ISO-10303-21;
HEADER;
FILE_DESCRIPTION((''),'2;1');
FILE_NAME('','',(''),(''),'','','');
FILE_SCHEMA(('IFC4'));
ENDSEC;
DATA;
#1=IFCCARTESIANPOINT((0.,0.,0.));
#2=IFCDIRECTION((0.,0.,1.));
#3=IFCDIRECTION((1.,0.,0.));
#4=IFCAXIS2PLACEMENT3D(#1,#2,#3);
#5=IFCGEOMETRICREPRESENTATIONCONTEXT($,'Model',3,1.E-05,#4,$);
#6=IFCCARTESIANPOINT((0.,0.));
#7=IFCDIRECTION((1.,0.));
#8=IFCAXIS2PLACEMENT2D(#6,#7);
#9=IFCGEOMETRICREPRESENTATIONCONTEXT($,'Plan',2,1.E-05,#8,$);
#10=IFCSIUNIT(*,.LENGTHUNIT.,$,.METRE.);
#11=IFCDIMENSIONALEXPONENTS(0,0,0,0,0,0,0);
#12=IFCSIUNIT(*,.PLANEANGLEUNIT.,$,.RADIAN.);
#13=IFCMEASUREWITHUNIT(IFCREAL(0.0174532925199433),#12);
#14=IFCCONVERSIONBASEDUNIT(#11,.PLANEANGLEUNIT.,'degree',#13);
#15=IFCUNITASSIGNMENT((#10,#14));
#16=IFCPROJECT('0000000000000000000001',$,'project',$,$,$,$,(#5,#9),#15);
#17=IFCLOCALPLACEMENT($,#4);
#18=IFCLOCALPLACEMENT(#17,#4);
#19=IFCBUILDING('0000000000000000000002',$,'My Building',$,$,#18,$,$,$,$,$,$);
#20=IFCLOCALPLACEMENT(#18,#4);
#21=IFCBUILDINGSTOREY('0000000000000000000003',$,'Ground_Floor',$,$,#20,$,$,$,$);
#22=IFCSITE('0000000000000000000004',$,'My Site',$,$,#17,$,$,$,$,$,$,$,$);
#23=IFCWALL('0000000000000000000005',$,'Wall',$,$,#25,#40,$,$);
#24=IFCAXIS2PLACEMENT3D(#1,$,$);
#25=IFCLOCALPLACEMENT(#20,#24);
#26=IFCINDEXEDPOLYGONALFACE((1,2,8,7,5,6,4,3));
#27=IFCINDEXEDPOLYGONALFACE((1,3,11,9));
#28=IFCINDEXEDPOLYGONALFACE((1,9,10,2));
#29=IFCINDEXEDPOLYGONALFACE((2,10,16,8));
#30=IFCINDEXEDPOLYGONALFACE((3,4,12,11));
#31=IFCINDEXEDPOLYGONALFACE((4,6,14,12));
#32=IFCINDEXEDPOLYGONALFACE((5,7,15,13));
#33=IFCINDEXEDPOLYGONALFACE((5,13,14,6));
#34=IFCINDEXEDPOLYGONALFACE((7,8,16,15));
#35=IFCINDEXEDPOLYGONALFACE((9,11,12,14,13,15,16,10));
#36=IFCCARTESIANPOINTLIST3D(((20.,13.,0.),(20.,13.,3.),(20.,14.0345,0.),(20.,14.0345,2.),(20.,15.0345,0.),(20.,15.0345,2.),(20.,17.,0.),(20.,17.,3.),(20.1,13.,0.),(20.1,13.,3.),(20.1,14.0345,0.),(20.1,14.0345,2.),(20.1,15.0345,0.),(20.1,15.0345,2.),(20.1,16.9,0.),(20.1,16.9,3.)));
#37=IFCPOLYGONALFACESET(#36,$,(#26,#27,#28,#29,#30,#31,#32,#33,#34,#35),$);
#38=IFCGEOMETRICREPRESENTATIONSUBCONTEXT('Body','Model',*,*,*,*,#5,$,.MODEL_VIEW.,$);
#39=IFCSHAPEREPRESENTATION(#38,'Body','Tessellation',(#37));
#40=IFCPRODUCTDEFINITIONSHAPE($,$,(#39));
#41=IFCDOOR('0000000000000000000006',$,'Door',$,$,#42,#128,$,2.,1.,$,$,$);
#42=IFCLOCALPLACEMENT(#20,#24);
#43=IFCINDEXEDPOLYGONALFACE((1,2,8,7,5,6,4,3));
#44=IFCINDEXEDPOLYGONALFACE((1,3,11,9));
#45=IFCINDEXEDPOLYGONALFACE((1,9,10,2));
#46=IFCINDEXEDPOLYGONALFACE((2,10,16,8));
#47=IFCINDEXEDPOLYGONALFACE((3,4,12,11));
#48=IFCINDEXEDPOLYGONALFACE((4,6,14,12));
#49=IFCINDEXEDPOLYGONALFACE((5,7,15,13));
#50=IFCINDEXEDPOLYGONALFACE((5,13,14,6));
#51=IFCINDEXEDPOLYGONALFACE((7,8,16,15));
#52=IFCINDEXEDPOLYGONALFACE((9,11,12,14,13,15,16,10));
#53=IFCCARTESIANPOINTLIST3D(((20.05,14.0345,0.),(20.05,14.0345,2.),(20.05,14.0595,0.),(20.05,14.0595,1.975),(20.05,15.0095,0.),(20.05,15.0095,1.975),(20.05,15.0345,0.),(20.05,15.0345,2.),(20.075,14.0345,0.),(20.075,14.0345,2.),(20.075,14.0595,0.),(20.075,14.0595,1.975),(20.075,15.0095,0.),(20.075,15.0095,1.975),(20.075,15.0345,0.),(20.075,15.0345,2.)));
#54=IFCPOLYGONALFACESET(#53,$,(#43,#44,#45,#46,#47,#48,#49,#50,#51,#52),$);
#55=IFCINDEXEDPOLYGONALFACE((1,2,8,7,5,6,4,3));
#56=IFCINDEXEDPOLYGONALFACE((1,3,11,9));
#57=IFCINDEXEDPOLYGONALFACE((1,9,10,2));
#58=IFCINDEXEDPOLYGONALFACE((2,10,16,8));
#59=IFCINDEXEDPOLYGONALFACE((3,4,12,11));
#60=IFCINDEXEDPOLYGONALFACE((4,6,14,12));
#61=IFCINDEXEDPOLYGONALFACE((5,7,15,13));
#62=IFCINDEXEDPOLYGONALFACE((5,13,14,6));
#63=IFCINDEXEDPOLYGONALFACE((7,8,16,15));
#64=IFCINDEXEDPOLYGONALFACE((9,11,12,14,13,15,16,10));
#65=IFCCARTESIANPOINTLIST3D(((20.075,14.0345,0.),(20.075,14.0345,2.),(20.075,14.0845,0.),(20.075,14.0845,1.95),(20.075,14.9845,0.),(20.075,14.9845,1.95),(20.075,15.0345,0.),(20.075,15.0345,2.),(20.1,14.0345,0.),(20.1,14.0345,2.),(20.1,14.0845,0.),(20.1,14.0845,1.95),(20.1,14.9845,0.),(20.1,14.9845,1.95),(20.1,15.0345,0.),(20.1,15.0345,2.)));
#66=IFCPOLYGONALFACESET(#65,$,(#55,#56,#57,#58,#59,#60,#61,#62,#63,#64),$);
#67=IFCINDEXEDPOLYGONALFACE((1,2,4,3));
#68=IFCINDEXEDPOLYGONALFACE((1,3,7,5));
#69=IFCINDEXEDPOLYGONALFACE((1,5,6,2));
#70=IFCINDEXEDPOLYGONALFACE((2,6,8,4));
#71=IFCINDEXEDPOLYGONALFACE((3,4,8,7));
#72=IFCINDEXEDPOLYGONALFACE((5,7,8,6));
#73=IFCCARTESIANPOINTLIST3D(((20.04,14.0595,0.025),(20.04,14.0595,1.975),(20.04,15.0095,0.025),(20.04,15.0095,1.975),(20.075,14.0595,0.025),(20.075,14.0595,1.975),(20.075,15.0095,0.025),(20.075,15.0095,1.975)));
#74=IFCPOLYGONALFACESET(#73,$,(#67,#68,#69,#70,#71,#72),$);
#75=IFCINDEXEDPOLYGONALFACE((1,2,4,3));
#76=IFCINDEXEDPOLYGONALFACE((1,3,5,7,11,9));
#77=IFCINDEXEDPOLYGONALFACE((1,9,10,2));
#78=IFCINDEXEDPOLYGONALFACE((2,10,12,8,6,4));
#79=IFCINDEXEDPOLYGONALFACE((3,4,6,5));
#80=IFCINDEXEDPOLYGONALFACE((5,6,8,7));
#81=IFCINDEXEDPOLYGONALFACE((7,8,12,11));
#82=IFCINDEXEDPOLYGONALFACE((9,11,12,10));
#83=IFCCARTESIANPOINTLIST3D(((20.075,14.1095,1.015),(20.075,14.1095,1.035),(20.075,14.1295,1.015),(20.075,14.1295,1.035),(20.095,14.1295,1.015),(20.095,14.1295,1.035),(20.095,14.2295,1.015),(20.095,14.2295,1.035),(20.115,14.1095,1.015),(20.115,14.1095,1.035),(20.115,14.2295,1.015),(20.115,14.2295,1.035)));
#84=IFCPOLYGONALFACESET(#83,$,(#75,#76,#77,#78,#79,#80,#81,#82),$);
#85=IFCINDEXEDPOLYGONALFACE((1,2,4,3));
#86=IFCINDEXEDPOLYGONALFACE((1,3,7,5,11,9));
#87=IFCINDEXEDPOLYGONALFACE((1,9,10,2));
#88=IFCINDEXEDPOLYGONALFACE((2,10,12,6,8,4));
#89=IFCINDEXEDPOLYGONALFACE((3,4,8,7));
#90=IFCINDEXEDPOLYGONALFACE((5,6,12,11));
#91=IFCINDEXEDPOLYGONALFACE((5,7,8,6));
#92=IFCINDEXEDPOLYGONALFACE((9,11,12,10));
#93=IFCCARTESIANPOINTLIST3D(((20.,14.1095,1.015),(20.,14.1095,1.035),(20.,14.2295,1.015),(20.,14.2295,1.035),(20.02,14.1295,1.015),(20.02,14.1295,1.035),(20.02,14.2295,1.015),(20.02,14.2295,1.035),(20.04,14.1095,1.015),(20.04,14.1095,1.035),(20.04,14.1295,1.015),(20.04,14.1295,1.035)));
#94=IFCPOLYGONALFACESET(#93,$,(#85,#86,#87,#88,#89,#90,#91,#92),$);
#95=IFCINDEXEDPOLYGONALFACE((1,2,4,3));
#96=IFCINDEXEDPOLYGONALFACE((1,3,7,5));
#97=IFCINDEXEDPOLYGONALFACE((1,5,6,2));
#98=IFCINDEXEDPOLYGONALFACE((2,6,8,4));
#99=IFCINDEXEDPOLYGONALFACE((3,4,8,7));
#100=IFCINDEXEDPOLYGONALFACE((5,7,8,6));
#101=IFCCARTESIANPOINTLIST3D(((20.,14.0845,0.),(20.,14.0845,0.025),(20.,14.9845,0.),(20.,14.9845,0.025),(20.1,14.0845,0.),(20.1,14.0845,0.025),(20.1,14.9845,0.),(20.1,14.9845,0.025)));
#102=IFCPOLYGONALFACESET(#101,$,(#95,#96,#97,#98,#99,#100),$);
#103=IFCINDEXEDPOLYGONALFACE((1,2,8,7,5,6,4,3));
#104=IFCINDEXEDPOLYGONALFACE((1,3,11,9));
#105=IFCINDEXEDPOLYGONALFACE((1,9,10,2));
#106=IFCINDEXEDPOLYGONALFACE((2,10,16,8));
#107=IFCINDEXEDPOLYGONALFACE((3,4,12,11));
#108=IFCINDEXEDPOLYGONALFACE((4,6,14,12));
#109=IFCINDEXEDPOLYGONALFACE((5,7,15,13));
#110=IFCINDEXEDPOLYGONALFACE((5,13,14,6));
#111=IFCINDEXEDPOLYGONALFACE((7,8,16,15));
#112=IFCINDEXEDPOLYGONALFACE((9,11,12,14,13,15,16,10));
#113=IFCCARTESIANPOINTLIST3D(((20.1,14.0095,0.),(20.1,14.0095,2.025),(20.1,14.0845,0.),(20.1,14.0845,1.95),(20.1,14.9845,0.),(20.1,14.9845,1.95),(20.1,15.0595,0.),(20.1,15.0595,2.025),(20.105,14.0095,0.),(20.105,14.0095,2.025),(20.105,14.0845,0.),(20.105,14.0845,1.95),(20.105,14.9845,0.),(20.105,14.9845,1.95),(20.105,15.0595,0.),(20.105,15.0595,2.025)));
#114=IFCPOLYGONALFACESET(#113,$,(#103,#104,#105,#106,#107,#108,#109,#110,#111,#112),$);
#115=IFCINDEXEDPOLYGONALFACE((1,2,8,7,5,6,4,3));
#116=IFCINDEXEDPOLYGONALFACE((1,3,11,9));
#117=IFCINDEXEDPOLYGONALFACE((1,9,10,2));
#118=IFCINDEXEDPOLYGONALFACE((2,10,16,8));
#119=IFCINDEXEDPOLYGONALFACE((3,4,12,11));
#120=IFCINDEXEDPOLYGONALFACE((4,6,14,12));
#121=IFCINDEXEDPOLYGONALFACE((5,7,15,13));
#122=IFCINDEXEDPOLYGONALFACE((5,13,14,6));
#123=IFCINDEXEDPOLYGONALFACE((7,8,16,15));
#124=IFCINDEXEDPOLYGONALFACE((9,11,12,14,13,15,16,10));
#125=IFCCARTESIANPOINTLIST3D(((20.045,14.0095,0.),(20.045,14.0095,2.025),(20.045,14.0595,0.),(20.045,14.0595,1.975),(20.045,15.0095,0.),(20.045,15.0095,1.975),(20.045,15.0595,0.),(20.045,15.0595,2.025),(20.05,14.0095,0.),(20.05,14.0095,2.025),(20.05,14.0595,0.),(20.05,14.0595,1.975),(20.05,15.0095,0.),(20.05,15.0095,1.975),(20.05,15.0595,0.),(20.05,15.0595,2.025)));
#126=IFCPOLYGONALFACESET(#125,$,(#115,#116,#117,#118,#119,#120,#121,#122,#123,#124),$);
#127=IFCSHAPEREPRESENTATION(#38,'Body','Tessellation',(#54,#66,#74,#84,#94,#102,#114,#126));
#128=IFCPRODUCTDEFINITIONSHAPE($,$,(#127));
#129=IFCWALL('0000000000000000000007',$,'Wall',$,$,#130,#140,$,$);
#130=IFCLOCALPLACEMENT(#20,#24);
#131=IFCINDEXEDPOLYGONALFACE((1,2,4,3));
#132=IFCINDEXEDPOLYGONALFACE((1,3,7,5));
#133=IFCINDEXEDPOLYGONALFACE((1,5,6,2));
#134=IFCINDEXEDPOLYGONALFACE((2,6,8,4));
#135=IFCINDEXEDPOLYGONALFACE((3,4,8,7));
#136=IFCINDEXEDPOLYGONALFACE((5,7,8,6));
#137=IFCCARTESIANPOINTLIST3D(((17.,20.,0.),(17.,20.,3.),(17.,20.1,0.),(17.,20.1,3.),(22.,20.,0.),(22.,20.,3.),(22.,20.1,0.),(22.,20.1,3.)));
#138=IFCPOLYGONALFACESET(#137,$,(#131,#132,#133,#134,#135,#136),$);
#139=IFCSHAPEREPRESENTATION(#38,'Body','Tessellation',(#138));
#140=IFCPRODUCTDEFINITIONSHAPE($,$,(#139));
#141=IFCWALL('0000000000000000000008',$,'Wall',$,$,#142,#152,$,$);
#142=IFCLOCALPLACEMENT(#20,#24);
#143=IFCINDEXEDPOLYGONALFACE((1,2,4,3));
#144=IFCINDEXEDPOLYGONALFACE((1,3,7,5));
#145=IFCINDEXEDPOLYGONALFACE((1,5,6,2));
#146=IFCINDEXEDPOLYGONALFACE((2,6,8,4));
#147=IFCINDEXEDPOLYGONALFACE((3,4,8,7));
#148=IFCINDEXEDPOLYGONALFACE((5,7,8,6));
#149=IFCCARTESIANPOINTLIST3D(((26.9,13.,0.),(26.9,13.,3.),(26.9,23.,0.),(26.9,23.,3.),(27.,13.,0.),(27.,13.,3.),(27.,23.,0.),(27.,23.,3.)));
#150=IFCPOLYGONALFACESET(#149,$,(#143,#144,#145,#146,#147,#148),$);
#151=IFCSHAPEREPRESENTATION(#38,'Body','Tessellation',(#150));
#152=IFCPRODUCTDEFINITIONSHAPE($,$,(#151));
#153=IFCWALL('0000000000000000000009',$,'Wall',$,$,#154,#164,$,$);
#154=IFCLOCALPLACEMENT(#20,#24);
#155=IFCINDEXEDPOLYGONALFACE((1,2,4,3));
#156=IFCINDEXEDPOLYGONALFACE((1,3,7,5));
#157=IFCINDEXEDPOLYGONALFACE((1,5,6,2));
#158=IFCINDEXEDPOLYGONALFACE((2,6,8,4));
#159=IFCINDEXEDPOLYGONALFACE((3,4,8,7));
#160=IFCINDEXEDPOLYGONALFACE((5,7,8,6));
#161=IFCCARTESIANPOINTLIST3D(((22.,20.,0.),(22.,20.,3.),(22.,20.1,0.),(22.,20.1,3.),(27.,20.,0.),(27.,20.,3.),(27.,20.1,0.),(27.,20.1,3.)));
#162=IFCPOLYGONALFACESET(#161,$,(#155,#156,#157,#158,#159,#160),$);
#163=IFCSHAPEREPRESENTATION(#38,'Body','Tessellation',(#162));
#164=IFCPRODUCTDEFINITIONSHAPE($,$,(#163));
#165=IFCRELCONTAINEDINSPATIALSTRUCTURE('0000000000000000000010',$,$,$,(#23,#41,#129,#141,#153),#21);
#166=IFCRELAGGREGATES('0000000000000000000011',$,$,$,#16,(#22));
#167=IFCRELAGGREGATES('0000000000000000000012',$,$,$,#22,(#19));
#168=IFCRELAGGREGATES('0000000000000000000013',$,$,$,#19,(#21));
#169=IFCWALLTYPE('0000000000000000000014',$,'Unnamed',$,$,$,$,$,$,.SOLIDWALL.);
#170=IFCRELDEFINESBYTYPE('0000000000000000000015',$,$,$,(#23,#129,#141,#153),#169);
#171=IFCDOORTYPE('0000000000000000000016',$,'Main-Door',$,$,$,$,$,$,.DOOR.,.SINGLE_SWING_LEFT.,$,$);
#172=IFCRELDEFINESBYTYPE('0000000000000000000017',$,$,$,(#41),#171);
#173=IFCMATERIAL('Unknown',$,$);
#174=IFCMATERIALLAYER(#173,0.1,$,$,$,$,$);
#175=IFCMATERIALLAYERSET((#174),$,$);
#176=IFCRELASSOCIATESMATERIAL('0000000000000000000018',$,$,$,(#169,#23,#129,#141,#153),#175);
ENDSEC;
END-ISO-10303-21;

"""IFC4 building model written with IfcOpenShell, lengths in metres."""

from ifc_helpers import new_model, entity, si_unit, converted_unit, frame, origin_with_axes, origin_2d_with_axis, place, context, subcontext, project, spatial, line, indexed_curve, outline, extrude, shape, source, transform, mapped, material, layer, layer_set, layer_usage, type_object, type_shapes, element, fill, save


model = new_model("IFC4")

# Units and contexts
model_context = context("Model", 3, precision=1e-05, world=origin_with_axes())
plan_context = context("Plan", 2, precision=1e-05, world=origin_2d_with_axis())
body_context_1 = subcontext(model_context, "Body", "Model", "MODEL_VIEW")
body_context_2 = subcontext(plan_context, "Body", "Plan", "PLAN_VIEW")
ifc_project = project(units=[si_unit("LENGTHUNIT", "METRE"), converted_unit("PLANEANGLEUNIT", "degree", entity("IfcReal", 0.0174532925199433), si_unit("PLANEANGLEUNIT", "RADIAN"), dimensions=[0, 0, 0, 0, 0, 0, 0])], contexts=[model_context, plan_context])

# Site, building, storey
site_placement = place(None, origin_with_axes())
site = spatial("IfcSite", under=ifc_project, at=site_placement, Name="My Site")
building_placement = place(site_placement, origin_with_axes())
building = spatial("IfcBuilding", under=site, at=building_placement, Name="My Building")
storey_placement = place(building_placement, origin_with_axes())
storey = spatial("IfcBuildingStorey", under=building, at=storey_placement, Name="Ground_Floor")

# Shared definitions
ifc_material = material(Name="Unknown")
ifc_layer = layer(ifc_material, 0.1)
ifc_layer_set = layer_set([ifc_layer])
wall_type = type_object("IfcWallType", Name="Unnamed", PredefinedType="SOLIDWALL", material=ifc_layer_set)

# Shared definitions
shared_shape_1 = source(origin_with_axes(), body_context_1, "Body", "SweptSolid", [
    extrude(outline(indexed_curve([(0.0, 0.0), (1.0, 0.0), (1.0, 2.0), (0.0, 2.0)], segments=[line(1, 2, 3, 4, 1)])), frame((0.0, -0.6, 0.0), z_axis=(0.0, -1.0, 0.0), x_axis=(1.0, 0.0, 0.0)), (0.0, 0.0, -1.0), 1.2),
])
door_type_1 = type_object("IfcDoorType", Name="Main-Door", OperationType="SINGLE_SWING_LEFT", PredefinedType="DOOR")
shared_shape_2 = source(origin_with_axes(), body_context_1, "Body", "SweptSolid", [
    extrude(outline(indexed_curve([(0.0, 0.0), (0.0, 2.0), (1.0, 2.0), (1.0, 0.0), (0.975, 0.0), (0.975, 1.975), (0.025, 1.975), (0.025, 0.0)], segments=[line(1, 2, 3, 4, 5, 6, 7, 8, 1)])), frame((0.0, 0.025, 0.0), z_axis=(0.0, -1.0, 0.0), x_axis=(1.0, 0.0, 0.0)), (0.0, 0.0, -1.0), 0.025),
    extrude(outline(indexed_curve([(0.0, 0.0), (0.0, 2.0), (1.0, 2.0), (1.0, 0.0), (0.95, 0.0), (0.95, 1.95), (0.05, 1.95), (0.05, 0.0)], segments=[line(1, 2, 3, 4, 5, 6, 7, 8, 1)])), frame((0.0, 0.0, 0.0), z_axis=(0.0, -1.0, 0.0), x_axis=(1.0, 0.0, 0.0)), (0.0, 0.0, -1.0), 0.025),
    extrude(outline(indexed_curve([(0.0, 0.0), (0.95, 0.0), (0.95, 0.035), (0.0, 0.035)], segments=[line(1, 2, 3, 4, 1)])), frame((0.025, 0.025, 0.025), z_axis=(0.0, 0.0, 1.0), x_axis=(1.0, 0.0, 0.0)), (0.0, 0.0, 1.0), 1.95),
    extrude(outline(indexed_curve([(0.0, 0.0), (0.0, -0.04), (0.12, -0.04), (0.12, -0.02), (0.02, -0.02), (0.02, 0.0)], segments=[line(1, 2, 3, 4, 5, 6, 1)])), frame((0.075, 0.025, 1.015), z_axis=(0.0, 0.0, 1.0), x_axis=(1.0, 0.0, 0.0)), (0.0, 0.0, 1.0), 0.02),
    extrude(outline(indexed_curve([(0.0, 0.0), (0.0, 0.04), (0.12, 0.04), (0.12, 0.02), (0.02, 0.02), (0.02, 0.0)], segments=[line(1, 2, 3, 4, 5, 6, 1)])), frame((0.075, 0.06, 1.015), z_axis=(0.0, 0.0, 1.0), x_axis=(1.0, 0.0, 0.0)), (0.0, 0.0, 1.0), 0.02),
    extrude(outline(indexed_curve([(0.0, 0.0), (0.9, 0.0), (0.9, 0.1), (0.0, 0.1)], segments=[line(1, 2, 3, 4, 1)])), frame((0.05, 0.0, 0.0), z_axis=(0.0, 0.0, 1.0), x_axis=(1.0, 0.0, 0.0)), (0.0, 0.0, 1.0), 0.025),
    extrude(outline(indexed_curve([(0.0, 0.0), (0.0, 2.025), (1.05, 2.025), (1.05, 0.0), (0.975, 0.0), (0.975, 1.95), (0.075, 1.95), (0.075, 0.0)], segments=[line(1, 2, 3, 4, 5, 6, 7, 8, 1)])), frame((-0.025, -0.005, 0.0), z_axis=(0.0, -1.0, 0.0), x_axis=(1.0, 0.0, 0.0)), (0.0, 0.0, -1.0), 0.005),
    extrude(outline(indexed_curve([(0.0, 0.0), (0.0, 2.025), (1.05, 2.025), (1.05, 0.0), (1.0, 0.0), (1.0, 1.975), (0.05, 1.975), (0.05, 0.0)], segments=[line(1, 2, 3, 4, 5, 6, 7, 8, 1)])), frame((-0.025, 0.05, 0.0), z_axis=(0.0, -1.0, 0.0), x_axis=(1.0, 0.0, 0.0)), (0.0, 0.0, -1.0), 0.005),
])
shared_shape_3 = source(origin_with_axes(), body_context_2, "Body", "Curve2D", [
    entity("IfcIndexedPolyCurve", entity("IfcCartesianPointList2D", [[0.0, 0.0], [0.0, 0.05], [0.025, 0.05], [0.025, 0.025], [0.05, 0.025], [0.05, 0.0]]), [entity("IfcLineIndex", [1, 2, 3, 4, 5, 6, 1])]),
    entity("IfcIndexedPolyCurve", entity("IfcCartesianPointList2D", [[1.0, 0.0], [1.0, 0.05], [0.975, 0.05], [0.975, 0.025], [0.95, 0.025], [0.95, 0.0]]), [entity("IfcLineIndex", [1, 2, 3, 4, 5, 6, 1])]),
    entity("IfcTrimmedCurve", entity("IfcEllipse", entity("IfcAxis2Placement2D", entity("IfcCartesianPoint", [0.94, 0.05]), entity("IfcDirection", [1.0, 0.0])), 0.915, 0.95), [entity("IfcCartesianPoint", [0.94, 1.0])], [entity("IfcCartesianPoint", [0.025, 0.05])], True, "CARTESIAN"),
    entity("IfcIndexedPolyCurve", entity("IfcCartesianPointList2D", [[0.975, 0.05], [0.94, 0.05], [0.94, 1.0], [0.975, 1.0]]), [entity("IfcLineIndex", [1, 2, 3, 4, 1])]),
])
type_shapes(door_type_1, [shared_shape_2, shared_shape_3])

# Wall, opening, door
ifc_layer_usage_1 = layer_usage(ifc_layer_set, "AXIS2", "POSITIVE", 0.0)
wall_1_placement = place(storey_placement, frame((20.0, 17.0, 0.0), z_axis=(0.0, 0.0, 1.0), x_axis=(0.0, -1.0, 0.0)))
wall_1 = element("IfcWall", 1, at=wall_1_placement, inside=storey, type_object=wall_type, material=ifc_layer_usage_1, Name="Wall", context=body_context_1, shape_type="SweptSolid", body=[
    extrude(outline(indexed_curve([(0.0, 0.0), (0.1, 0.1), (4.0, 0.1), (4.0, 0.0)], segments=[line(1, 2, 3, 4, 1)])), origin_with_axes(), (0.0, 0.0, 1.0), 3.0),
])
opening_1_placement = place(wall_1_placement, frame((2.9655, 0.1, 0.0), z_axis=(0.0, 0.0, 1.0), x_axis=(-1.0, 0.0, 0.0)))
opening_1 = element("IfcOpeningElement", 2, at=opening_1_placement, cuts=wall_1, PredefinedType="OPENING", context=body_context_1, shape_type="MappedRepresentation", body=[
    mapped(shared_shape_1, transform((0.0, 0.0, 0.0), x_axis=(1.0, 0.0, 0.0), y_axis=(0.0, 1.0, 0.0), z_axis=(0.0, 0.0, 1.0), scale=1.0)),
])
door_1_placement = place(opening_1_placement, frame((0.0, 0.0, 0.0), z_axis=(0.0, 0.0, 1.0), x_axis=(1.0, 0.0, 0.0)))
door_1 = element("IfcDoor", 3, at=door_1_placement, inside=storey, type_object=door_type_1, Name="Door", OverallHeight=2.0, OverallWidth=1.0, shapes=[
    shape(body_context_1, "Body", "MappedRepresentation", [mapped(shared_shape_2, transform((0.0, 0.0, 0.0), x_axis=(1.0, 0.0, 0.0), y_axis=(0.0, 1.0, 0.0), z_axis=(0.0, 0.0, 1.0), scale=1.0))]),
    shape(body_context_2, "Body", "MappedRepresentation", [mapped(shared_shape_3, transform((0.0, 0.0, 0.0), x_axis=(1.0, 0.0, 0.0), y_axis=(0.0, 1.0, 0.0), z_axis=(0.0, 0.0, 1.0), scale=1.0))]),
])
fill(opening_1, door_1)

# Walls
ifc_layer_usage_2 = layer_usage(ifc_layer_set, "AXIS2", "POSITIVE", 0.0)
wall_2_placement = place(storey_placement, frame((17.0, 20.0, 0.0), z_axis=(0.0, 0.0, 1.0), x_axis=(1.0, 0.0, 0.0)))
element("IfcWall", 4, at=wall_2_placement, inside=storey, type_object=wall_type, material=ifc_layer_usage_2, Name="Wall", context=body_context_1, shape_type="SweptSolid", body=[
    extrude(outline(indexed_curve([(0.0, 0.0), (0.0, 0.1), (5.0, 0.1), (5.0, 0.0)], segments=[line(1, 2, 3, 4, 1)])), origin_with_axes(), (0.0, 0.0, 1.0), 3.0),
])
ifc_layer_usage_3 = layer_usage(ifc_layer_set, "AXIS2", "POSITIVE", 0.0)
wall_3_placement = place(storey_placement, frame((27.0, 13.0, 0.0), z_axis=(0.0, 0.0, 1.0), x_axis=(0.0, 1.0, 0.0)))
element("IfcWall", 5, at=wall_3_placement, inside=storey, type_object=wall_type, material=ifc_layer_usage_3, Name="Wall", context=body_context_1, shape_type="SweptSolid", body=[
    extrude(outline(indexed_curve([(0.0, 0.0), (0.0, 0.1), (10.0, 0.1), (10.0, 0.0)], segments=[line(1, 2, 3, 4, 1)])), origin_with_axes(), (0.0, 0.0, 1.0), 3.0),
])
ifc_layer_usage_4 = layer_usage(ifc_layer_set, "AXIS2", "POSITIVE", 0.0)
wall_4_placement = place(storey_placement, frame((22.0, 20.0, 0.0), z_axis=(0.0, 0.0, 1.0), x_axis=(1.0, 0.0, 0.0)))
element("IfcWall", 6, at=wall_4_placement, inside=storey, type_object=wall_type, material=ifc_layer_usage_4, Name="Wall", context=body_context_1, shape_type="SweptSolid", body=[
    extrude(outline(indexed_curve([(0.0, 0.0), (0.0, 0.1), (5.0, 0.1), (5.0, 0.0)], segments=[line(1, 2, 3, 4, 1)])), origin_with_axes(), (0.0, 0.0, 1.0), 3.0),
])

save(model, "model.ifc")
